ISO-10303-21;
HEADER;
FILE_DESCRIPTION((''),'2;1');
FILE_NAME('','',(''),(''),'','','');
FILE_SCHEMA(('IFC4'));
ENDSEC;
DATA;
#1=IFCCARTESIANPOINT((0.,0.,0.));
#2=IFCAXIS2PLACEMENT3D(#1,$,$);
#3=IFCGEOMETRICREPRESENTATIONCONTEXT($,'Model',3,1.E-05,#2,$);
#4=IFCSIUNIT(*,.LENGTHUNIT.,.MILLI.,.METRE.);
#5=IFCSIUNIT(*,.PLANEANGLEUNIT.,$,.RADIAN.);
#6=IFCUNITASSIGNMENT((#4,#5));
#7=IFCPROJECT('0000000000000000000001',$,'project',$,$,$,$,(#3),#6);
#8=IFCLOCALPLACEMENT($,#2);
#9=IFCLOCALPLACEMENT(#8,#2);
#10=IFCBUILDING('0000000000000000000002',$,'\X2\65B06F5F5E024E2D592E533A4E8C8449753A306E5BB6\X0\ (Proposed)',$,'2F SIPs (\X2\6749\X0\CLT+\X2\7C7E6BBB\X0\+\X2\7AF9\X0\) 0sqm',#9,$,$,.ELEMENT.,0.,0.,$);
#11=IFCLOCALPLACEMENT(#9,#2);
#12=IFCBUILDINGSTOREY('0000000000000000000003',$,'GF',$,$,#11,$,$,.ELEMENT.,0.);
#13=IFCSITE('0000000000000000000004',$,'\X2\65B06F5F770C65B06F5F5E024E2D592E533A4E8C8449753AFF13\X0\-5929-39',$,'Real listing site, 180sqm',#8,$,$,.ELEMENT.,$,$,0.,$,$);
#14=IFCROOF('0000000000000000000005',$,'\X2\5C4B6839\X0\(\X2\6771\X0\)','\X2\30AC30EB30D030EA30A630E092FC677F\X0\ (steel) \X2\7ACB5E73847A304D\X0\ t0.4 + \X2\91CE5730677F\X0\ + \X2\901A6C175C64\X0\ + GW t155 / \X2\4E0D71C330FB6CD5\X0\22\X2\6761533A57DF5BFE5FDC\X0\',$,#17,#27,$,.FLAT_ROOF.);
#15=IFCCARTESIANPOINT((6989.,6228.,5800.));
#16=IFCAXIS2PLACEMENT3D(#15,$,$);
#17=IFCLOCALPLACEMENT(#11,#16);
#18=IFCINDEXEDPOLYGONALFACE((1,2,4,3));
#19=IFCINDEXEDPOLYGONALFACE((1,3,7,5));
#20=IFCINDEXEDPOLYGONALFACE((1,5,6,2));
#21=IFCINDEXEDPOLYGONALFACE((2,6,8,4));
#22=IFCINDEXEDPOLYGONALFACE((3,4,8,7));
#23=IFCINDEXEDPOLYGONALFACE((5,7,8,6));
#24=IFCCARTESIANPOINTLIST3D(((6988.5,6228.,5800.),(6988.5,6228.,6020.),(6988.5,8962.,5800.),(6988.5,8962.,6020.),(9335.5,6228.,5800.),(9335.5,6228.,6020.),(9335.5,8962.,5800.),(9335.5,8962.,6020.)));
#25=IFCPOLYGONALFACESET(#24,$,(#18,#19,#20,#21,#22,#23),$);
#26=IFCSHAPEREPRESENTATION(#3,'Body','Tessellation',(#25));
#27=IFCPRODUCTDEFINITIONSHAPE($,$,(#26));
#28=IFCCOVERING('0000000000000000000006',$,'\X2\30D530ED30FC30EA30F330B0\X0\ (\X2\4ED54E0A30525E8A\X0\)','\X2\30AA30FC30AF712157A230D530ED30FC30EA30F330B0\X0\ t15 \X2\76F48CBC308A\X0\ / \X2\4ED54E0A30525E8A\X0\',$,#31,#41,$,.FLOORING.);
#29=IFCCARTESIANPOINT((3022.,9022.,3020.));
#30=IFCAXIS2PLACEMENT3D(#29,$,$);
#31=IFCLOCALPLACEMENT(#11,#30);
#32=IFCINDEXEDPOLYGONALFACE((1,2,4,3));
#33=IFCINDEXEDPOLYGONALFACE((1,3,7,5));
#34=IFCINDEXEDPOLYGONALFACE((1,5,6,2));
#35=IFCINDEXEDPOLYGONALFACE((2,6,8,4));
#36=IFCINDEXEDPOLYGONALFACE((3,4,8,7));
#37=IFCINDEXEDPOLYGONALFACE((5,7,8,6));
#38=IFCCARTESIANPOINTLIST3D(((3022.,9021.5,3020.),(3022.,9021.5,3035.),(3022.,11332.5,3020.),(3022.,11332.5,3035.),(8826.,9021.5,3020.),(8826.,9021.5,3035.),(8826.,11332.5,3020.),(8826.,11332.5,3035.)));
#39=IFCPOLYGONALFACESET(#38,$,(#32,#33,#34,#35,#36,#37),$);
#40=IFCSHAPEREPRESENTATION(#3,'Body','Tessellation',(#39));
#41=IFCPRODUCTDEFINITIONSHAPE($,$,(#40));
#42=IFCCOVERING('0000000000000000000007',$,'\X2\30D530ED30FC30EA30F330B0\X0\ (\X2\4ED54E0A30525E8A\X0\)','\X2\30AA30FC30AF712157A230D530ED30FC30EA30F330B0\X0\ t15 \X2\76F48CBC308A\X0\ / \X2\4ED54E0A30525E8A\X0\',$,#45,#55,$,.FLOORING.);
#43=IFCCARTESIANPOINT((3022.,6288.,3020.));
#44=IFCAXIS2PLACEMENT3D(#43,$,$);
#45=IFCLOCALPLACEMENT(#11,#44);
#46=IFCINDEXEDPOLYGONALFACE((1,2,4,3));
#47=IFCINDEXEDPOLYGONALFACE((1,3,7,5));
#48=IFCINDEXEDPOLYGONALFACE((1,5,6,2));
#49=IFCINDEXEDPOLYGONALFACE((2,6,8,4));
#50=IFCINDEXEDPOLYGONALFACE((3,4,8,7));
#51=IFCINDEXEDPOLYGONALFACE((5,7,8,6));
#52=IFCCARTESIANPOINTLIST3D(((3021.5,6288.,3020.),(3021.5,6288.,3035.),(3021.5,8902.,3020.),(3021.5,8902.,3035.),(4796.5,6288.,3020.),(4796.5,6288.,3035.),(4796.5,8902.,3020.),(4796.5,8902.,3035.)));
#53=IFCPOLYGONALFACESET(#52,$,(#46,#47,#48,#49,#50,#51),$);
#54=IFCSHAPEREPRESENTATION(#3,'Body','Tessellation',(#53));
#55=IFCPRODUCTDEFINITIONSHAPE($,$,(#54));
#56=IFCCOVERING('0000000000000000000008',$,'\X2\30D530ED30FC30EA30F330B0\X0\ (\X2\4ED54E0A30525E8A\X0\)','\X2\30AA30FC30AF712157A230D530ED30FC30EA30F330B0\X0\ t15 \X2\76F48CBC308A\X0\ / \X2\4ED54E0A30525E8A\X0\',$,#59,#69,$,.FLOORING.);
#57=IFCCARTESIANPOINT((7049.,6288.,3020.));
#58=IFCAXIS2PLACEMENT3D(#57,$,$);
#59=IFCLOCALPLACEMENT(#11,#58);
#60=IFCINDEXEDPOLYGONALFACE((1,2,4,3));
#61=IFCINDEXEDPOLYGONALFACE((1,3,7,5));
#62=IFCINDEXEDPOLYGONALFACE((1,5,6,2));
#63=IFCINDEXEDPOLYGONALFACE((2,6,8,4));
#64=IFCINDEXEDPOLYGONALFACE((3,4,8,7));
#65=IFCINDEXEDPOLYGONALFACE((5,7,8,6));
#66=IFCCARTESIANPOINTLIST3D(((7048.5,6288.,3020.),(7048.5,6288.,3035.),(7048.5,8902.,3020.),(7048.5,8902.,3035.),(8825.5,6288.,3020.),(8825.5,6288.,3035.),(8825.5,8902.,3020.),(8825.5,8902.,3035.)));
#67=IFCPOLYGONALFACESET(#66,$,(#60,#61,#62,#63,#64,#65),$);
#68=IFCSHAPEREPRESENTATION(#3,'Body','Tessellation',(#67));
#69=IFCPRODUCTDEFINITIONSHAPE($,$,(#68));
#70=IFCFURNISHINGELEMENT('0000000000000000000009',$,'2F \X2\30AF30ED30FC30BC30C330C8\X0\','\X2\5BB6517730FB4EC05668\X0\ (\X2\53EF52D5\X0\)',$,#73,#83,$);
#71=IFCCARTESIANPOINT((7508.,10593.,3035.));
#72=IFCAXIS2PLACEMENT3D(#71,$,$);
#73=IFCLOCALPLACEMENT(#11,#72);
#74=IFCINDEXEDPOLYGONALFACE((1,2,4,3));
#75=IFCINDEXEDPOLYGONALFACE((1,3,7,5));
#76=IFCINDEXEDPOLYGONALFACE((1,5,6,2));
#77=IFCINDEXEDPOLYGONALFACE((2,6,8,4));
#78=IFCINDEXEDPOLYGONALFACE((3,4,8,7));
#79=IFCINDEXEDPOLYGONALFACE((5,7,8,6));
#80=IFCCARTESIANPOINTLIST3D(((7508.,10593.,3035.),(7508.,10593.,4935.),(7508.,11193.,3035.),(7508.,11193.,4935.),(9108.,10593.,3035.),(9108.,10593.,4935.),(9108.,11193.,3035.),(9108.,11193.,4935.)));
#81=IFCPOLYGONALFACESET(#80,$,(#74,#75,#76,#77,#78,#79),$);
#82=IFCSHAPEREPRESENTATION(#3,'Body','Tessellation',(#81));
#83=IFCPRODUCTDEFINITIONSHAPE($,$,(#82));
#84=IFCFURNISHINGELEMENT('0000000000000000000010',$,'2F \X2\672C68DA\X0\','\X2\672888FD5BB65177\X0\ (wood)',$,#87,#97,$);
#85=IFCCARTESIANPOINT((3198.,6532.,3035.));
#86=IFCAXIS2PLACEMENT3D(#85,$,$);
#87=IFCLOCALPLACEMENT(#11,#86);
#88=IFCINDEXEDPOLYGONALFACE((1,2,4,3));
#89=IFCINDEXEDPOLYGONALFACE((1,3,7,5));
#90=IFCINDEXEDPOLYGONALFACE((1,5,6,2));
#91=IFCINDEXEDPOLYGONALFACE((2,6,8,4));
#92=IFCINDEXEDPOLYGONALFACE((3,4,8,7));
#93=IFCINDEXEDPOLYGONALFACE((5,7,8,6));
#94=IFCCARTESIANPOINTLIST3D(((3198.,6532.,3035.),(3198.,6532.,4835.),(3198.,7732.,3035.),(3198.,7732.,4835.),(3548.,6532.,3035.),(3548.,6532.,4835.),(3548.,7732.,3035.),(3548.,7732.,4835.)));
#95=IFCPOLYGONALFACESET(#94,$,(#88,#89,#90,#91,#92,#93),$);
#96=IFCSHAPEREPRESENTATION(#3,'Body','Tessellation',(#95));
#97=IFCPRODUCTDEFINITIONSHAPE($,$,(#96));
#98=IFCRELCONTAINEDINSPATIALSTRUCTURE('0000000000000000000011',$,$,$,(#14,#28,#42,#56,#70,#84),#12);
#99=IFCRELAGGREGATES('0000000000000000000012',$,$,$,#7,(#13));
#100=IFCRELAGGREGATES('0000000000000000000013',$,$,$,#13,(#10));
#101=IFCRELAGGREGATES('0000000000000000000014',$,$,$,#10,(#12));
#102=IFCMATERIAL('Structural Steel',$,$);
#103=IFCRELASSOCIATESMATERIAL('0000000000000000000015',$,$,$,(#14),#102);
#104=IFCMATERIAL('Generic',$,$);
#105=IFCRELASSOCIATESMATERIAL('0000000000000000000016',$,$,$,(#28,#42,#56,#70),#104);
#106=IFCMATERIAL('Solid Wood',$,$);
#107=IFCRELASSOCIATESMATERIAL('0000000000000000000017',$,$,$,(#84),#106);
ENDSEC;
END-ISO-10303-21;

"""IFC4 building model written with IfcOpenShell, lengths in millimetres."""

from ifc_helpers import new_model, si_unit, frame, frame_2d, origin, place, context, project, spatial, rectangle, extrude, material, element, save


model = new_model("IFC4")

# Units and contexts
model_context = context("Model", 3, precision=1e-05, world=origin())
ifc_project = project(units=[si_unit("LENGTHUNIT", "METRE", prefix="MILLI"), si_unit("PLANEANGLEUNIT", "RADIAN")], contexts=[model_context])

# Site, building, storey
site_placement = place(None, origin())
site = spatial("IfcSite", under=ifc_project, at=site_placement, Name="新潟県新潟市中央区二葉町３-5929-39", ObjectType="Real listing site, 180sqm", CompositionType="ELEMENT", RefElevation=0.0)
building_placement = place(site_placement, origin())
building = spatial("IfcBuilding", under=site, at=building_placement, Name="新潟市中央区二葉町の家 (Proposed)", ObjectType="2F SIPs (杉CLT+籾殻+竹) 0sqm", CompositionType="ELEMENT", ElevationOfRefHeight=0.0, ElevationOfTerrain=0.0)
storey_placement = place(building_placement, origin())
storey = spatial("IfcBuildingStorey", under=building, at=storey_placement, Name="GF", CompositionType="ELEMENT", Elevation=0.0)

# Shared definitions
ifc_material_1 = material(Name="Solid Wood")

# Roof
ifc_material_2 = material(Name="Structural Steel")
roof_1_placement = place(storey_placement, frame((6989.0, 6228.0, 5800.0)))
element("IfcRoof", 1, at=roof_1_placement, inside=storey, material=ifc_material_2, Name="屋根(東)", Description="ガルバリウム鋼板 (steel) 立平葺き t0.4 + 野地板 + 通気層 + GW t155 / 不燃・法22条区域対応", PredefinedType="FLAT_ROOF", context=model_context, shape_type="SweptSolid", body=[
    extrude(rectangle(XDim=2347.0, YDim=2734.0, at=frame_2d((1173.0, 1367.0))), frame((6989.0, 6228.0, 5800.0)), (0.0, 0.0, 1.0), 220.0),
])

# Coverings
ifc_material_3 = material(Name="Generic")
covering_1_placement = place(storey_placement, frame((3022.0, 9022.0, 3020.0)))
element("IfcCovering", 2, at=covering_1_placement, inside=storey, material=ifc_material_3, Name="フローリング (仕上げ床)", Description="オーク無垢フローリング t15 直貼り / 仕上げ床", PredefinedType="FLOORING", context=model_context, shape_type="SweptSolid", body=[
    extrude(rectangle(XDim=5804.0, YDim=2311.0, at=frame_2d((2902.0, 1155.0))), frame((3022.0, 9022.0, 3020.0)), (0.0, 0.0, 1.0), 15.0),
])
covering_2_placement = place(storey_placement, frame((3022.0, 6288.0, 3020.0)))
element("IfcCovering", 3, at=covering_2_placement, inside=storey, material=ifc_material_3, Name="フローリング (仕上げ床)", Description="オーク無垢フローリング t15 直貼り / 仕上げ床", PredefinedType="FLOORING", context=model_context, shape_type="SweptSolid", body=[
    extrude(rectangle(XDim=1775.0, YDim=2614.0, at=frame_2d((887.0, 1307.0))), frame((3022.0, 6288.0, 3020.0)), (0.0, 0.0, 1.0), 15.0),
])
covering_3_placement = place(storey_placement, frame((7049.0, 6288.0, 3020.0)))
element("IfcCovering", 4, at=covering_3_placement, inside=storey, material=ifc_material_3, Name="フローリング (仕上げ床)", Description="オーク無垢フローリング t15 直貼り / 仕上げ床", PredefinedType="FLOORING", context=model_context, shape_type="SweptSolid", body=[
    extrude(rectangle(XDim=1777.0, YDim=2614.0, at=frame_2d((888.0, 1307.0))), frame((7049.0, 6288.0, 3020.0)), (0.0, 0.0, 1.0), 15.0),
])

# Furnishing elements
furnishing_1_placement = place(storey_placement, frame((7508.0, 10593.0, 3035.0)))
element("IfcFurnishingElement", 5, at=furnishing_1_placement, inside=storey, material=ifc_material_3, Name="2F クローゼット", Description="家具・什器 (可動)", context=model_context, shape_type="SweptSolid", body=[
    extrude(rectangle(XDim=1600.0, YDim=600.0, at=frame_2d((800.0, 300.0))), frame((7508.0, 10593.0, 3035.0)), (0.0, 0.0, 1.0), 1900.0),
])
furnishing_2_placement = place(storey_placement, frame((3198.0, 6532.0, 3035.0)))
element("IfcFurnishingElement", 6, at=furnishing_2_placement, inside=storey, material=ifc_material_1, Name="2F 本棚", Description="木製家具 (wood)", context=model_context, shape_type="SweptSolid", body=[
    extrude(rectangle(XDim=350.0, YDim=1200.0, at=frame_2d((175.0, 600.0))), frame((3198.0, 6532.0, 3035.0)), (0.0, 0.0, 1.0), 1800.0),
])

save(model, "model.ifc")
